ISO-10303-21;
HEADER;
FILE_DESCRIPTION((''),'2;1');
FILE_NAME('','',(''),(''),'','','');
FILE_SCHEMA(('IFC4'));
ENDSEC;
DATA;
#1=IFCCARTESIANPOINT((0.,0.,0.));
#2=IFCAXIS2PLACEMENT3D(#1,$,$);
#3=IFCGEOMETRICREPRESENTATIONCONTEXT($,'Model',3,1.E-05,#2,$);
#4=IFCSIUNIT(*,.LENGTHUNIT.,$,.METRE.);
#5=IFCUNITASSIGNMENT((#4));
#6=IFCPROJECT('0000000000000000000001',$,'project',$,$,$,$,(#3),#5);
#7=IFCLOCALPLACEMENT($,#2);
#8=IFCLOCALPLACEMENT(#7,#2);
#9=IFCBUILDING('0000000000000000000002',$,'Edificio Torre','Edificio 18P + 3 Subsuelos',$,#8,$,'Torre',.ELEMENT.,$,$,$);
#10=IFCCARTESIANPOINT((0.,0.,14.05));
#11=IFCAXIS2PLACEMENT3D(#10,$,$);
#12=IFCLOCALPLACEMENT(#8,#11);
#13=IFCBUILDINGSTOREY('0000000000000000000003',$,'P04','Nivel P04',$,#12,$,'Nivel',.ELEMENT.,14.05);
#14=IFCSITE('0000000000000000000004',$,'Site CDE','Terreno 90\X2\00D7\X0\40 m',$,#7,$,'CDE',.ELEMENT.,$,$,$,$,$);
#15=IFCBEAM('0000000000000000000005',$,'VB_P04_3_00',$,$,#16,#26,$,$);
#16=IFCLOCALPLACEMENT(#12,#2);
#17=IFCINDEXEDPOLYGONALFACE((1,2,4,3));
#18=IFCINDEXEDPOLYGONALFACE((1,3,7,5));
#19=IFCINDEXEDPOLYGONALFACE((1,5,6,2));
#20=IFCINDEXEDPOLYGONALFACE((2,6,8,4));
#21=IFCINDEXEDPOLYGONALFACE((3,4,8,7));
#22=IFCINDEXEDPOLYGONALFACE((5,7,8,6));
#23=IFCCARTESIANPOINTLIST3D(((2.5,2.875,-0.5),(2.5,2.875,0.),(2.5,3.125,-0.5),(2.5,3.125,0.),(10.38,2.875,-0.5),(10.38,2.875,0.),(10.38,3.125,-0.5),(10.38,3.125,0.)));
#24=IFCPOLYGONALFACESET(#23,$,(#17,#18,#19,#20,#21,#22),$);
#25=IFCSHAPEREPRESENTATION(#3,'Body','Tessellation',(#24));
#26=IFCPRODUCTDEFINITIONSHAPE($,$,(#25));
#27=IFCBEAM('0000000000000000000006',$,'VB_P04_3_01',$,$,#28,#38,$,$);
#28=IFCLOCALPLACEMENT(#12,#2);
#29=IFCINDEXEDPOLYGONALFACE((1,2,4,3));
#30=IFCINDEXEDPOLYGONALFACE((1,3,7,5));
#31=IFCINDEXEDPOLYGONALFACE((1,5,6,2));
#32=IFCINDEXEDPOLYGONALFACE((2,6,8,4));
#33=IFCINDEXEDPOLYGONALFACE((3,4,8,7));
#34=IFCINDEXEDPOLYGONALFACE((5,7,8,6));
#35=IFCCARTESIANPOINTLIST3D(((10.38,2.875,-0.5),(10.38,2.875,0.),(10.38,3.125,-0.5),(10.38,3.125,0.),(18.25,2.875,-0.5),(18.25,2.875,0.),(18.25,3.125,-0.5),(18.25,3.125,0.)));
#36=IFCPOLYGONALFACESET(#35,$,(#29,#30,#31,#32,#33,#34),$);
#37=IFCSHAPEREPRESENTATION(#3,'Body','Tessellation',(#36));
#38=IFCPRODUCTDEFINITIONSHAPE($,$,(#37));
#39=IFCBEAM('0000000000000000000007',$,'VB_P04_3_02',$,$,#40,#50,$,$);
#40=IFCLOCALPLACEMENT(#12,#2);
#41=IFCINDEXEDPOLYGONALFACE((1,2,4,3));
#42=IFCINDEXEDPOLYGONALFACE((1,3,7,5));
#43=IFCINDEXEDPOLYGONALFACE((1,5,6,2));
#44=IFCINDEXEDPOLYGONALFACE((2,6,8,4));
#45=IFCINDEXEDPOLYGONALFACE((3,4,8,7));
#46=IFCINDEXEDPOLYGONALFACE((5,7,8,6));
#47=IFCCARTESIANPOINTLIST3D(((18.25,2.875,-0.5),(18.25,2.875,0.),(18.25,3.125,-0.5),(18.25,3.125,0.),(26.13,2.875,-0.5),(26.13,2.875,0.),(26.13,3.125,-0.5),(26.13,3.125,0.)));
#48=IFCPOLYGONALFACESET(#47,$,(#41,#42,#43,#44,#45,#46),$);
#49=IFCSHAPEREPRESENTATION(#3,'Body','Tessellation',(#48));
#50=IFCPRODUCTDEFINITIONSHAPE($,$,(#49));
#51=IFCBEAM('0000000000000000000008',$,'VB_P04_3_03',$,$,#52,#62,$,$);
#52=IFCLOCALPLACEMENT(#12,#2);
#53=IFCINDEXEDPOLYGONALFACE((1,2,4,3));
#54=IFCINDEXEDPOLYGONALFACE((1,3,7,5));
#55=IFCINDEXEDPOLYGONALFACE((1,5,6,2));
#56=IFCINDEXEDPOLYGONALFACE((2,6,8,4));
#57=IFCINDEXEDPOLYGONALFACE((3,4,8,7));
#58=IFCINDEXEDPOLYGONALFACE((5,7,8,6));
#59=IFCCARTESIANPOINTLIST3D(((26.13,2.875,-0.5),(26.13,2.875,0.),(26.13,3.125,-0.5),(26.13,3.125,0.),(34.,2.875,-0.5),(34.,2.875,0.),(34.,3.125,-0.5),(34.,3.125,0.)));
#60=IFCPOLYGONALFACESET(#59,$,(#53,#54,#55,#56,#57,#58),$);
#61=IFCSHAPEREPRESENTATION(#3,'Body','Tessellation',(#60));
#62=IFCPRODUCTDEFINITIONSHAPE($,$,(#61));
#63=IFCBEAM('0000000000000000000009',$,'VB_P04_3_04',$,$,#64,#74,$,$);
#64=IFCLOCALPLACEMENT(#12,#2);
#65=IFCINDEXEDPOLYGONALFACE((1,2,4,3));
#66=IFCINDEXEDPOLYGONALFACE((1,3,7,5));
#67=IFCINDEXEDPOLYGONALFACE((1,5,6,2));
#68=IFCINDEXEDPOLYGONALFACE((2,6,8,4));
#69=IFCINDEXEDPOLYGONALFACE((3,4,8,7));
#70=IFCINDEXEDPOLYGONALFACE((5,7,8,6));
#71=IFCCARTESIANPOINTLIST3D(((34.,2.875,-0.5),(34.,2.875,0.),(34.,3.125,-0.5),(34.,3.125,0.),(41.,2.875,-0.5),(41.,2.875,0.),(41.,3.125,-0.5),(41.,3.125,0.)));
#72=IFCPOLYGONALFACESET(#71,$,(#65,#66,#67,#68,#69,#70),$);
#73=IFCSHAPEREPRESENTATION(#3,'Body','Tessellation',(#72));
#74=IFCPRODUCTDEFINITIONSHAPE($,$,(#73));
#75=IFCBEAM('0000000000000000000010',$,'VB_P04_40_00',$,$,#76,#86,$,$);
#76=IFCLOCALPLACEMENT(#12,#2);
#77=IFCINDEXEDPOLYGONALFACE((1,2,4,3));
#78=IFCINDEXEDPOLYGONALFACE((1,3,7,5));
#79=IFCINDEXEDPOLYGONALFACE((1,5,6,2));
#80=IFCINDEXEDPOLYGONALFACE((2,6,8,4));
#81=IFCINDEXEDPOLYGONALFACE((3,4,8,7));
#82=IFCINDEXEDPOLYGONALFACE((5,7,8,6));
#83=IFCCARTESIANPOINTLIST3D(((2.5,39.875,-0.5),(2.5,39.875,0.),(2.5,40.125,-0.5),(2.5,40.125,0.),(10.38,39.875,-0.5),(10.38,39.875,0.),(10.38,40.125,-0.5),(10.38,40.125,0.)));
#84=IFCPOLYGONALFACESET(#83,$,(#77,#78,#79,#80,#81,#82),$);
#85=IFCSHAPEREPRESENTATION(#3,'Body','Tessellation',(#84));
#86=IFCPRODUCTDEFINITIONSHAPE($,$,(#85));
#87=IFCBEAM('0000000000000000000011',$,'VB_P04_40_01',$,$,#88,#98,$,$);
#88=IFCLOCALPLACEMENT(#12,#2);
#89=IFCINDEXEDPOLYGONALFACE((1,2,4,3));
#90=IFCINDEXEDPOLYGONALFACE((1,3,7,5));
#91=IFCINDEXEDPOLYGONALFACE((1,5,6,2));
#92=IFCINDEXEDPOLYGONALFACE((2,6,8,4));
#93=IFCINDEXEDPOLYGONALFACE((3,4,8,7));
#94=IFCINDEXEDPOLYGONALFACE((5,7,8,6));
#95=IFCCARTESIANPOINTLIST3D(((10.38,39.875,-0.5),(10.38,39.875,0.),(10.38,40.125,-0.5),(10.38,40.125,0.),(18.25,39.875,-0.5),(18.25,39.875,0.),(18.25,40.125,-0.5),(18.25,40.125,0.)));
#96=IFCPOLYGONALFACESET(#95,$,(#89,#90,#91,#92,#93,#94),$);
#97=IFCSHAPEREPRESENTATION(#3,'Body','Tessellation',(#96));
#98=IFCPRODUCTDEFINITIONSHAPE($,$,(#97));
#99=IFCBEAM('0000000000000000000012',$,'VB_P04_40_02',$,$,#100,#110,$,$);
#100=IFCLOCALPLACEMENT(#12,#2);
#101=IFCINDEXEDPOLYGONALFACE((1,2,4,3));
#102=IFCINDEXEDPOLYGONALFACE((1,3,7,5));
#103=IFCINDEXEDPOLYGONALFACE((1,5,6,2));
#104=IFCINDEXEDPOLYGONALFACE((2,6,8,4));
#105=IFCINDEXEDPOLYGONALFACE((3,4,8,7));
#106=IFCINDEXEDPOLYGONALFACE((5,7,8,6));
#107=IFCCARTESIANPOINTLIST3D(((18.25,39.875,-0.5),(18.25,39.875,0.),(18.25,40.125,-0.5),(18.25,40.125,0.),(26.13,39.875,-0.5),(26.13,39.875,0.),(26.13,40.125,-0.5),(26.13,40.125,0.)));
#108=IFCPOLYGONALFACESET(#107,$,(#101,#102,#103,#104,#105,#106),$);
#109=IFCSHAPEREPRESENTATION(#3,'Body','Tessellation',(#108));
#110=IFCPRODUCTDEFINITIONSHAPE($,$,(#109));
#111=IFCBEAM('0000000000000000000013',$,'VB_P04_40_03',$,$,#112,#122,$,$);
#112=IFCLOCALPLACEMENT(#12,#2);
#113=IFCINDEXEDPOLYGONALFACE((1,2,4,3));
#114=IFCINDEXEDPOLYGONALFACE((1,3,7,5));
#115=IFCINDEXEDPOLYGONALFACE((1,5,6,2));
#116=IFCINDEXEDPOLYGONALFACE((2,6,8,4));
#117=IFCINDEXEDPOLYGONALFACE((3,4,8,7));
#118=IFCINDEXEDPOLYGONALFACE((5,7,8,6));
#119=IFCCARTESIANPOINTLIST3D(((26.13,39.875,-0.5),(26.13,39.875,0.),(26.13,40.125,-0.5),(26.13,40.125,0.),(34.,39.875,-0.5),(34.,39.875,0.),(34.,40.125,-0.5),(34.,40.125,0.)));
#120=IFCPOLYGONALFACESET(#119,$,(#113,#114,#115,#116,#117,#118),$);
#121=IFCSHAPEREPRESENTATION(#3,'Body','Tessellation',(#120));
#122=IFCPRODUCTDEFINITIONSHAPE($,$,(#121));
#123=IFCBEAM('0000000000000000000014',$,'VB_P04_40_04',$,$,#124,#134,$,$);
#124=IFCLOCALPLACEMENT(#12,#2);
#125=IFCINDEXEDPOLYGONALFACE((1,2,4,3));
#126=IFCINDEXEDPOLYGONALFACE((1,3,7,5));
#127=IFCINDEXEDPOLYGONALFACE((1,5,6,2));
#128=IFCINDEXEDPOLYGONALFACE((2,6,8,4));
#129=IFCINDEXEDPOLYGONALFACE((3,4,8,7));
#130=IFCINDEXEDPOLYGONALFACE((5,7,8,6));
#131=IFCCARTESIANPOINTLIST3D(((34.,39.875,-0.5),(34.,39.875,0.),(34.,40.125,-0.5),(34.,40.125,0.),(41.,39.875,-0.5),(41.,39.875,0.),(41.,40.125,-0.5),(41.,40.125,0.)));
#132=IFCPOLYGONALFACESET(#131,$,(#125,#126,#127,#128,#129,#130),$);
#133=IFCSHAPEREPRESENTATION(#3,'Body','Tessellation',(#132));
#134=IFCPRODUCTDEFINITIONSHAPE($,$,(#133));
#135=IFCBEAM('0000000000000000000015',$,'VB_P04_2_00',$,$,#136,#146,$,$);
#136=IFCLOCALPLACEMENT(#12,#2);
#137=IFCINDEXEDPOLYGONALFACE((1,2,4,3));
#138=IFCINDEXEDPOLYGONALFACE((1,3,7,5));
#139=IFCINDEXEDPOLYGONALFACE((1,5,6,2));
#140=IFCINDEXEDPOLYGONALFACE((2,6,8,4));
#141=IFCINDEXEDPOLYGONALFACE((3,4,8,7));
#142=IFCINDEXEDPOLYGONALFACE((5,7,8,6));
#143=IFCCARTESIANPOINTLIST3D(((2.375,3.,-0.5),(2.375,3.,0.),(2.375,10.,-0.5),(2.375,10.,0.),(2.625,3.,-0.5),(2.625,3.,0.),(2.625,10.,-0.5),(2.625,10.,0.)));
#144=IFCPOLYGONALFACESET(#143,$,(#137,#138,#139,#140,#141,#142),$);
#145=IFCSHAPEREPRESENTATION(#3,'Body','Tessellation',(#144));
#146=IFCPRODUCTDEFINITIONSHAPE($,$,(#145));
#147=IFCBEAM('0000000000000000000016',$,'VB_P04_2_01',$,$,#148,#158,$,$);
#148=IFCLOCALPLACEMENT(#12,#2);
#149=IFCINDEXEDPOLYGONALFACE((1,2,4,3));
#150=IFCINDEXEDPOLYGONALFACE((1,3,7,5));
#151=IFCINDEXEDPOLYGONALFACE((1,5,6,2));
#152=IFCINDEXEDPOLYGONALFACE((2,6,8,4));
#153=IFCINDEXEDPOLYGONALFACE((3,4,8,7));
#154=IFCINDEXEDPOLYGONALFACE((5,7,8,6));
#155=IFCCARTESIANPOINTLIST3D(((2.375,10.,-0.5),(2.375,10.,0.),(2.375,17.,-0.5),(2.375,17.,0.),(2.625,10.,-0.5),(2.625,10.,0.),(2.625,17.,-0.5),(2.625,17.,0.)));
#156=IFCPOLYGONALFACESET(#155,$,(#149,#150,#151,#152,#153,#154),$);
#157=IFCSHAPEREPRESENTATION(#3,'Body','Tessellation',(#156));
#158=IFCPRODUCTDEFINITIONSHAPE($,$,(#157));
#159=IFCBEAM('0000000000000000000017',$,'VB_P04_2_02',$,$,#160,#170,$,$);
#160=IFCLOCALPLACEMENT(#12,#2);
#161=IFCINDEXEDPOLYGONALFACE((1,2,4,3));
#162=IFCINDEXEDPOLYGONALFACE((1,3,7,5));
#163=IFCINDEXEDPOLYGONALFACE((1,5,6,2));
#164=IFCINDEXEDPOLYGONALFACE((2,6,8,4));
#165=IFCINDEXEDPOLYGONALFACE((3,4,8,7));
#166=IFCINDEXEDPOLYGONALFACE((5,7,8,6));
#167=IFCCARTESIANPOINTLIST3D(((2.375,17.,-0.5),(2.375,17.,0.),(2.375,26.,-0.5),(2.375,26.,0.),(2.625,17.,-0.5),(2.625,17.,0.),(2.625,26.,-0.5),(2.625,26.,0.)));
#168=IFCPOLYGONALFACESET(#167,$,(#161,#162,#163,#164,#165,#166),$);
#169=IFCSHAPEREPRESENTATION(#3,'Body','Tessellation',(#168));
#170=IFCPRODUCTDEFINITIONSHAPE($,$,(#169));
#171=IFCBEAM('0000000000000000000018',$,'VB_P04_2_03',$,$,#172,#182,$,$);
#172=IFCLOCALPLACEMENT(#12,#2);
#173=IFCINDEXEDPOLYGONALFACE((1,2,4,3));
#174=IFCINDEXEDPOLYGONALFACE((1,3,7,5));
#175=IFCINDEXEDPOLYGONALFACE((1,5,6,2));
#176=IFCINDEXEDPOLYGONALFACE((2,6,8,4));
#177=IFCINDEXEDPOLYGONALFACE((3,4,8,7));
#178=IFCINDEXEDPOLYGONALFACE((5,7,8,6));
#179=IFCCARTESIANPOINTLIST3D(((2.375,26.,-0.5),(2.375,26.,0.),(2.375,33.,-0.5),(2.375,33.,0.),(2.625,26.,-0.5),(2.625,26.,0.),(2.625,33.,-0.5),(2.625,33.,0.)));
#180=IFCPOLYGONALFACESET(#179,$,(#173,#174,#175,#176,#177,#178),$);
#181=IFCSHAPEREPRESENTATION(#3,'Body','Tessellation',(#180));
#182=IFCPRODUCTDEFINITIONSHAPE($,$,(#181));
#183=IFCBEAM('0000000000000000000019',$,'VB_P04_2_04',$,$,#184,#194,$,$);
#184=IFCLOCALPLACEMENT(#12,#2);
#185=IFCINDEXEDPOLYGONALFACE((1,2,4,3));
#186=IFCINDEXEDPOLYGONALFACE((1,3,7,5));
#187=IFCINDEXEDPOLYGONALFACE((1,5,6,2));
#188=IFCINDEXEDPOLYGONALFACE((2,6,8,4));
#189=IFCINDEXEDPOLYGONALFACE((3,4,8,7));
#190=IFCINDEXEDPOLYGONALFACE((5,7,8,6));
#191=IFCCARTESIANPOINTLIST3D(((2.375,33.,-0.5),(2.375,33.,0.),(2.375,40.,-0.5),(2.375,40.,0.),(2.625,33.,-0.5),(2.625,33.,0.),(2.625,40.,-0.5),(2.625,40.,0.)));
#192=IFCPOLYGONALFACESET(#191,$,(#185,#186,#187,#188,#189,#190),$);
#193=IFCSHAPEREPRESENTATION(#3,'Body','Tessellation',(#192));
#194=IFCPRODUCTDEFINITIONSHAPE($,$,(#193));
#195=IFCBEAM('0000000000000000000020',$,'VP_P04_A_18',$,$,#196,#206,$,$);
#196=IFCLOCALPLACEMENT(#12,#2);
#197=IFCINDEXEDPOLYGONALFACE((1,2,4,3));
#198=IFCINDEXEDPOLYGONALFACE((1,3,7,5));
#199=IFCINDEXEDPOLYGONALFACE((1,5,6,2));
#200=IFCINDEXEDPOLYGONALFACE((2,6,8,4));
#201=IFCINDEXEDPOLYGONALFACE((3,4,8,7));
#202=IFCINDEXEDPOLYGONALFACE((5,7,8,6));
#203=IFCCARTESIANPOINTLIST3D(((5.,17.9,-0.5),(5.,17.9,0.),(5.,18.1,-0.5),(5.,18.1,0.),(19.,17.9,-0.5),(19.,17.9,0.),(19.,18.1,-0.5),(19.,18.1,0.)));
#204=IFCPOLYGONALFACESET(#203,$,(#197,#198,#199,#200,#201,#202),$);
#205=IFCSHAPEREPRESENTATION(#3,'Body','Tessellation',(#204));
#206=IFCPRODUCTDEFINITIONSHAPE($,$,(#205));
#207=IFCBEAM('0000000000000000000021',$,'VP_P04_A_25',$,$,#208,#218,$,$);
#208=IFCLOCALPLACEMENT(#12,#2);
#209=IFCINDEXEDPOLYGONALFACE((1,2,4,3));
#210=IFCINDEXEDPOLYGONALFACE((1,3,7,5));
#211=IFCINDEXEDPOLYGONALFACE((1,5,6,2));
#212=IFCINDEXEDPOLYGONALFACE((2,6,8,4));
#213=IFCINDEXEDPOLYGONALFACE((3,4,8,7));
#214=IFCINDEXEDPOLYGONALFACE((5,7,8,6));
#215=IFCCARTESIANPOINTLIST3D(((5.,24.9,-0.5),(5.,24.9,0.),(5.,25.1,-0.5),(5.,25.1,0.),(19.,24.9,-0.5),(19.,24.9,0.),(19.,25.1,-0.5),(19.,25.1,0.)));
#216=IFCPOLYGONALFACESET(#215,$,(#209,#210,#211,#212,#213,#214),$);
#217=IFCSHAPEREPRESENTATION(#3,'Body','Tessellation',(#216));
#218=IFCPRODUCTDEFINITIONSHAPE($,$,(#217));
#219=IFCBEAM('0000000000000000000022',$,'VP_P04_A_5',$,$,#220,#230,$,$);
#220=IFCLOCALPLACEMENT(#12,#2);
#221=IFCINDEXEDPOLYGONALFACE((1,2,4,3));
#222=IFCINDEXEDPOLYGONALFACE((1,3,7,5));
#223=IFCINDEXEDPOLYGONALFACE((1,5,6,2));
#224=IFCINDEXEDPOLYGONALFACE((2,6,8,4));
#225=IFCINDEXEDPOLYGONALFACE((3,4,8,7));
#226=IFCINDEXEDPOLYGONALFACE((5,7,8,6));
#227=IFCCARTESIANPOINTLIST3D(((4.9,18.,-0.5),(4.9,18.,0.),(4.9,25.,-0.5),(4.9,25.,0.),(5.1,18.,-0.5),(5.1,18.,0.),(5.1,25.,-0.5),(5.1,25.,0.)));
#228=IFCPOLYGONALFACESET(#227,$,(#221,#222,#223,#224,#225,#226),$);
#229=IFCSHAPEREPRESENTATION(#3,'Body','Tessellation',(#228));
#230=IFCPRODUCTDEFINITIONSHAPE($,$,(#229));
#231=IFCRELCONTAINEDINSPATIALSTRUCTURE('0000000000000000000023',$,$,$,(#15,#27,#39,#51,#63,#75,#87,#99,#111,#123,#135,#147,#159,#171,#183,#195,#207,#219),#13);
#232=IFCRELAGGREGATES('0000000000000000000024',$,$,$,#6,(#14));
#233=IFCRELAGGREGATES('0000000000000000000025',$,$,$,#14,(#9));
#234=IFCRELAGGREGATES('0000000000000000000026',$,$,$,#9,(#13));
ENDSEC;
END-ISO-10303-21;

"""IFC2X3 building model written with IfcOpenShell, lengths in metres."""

from ifc_helpers import new_model, si_unit, frame, origin, origin_2d, place, context, project, spatial, rectangle, extrude, element, save


model = new_model("IFC2X3")

# Units and contexts
model_context = context("Model", 3, precision=1e-05, world=origin())
ifc_project = project(units=[si_unit("LENGTHUNIT", "METRE")], contexts=[model_context])

# Site, building, storey
site_placement = place(None, origin())
site = spatial("IfcSite", under=ifc_project, at=site_placement, Name="Site CDE", Description="Terreno 90×40 m", LongName="CDE", CompositionType="ELEMENT")
building_placement = place(site_placement, origin())
building = spatial("IfcBuilding", under=site, at=building_placement, Name="Edificio Torre", Description="Edificio 18P + 3 Subsuelos", LongName="Torre", CompositionType="ELEMENT")
storey_placement = place(building_placement, frame((0.0, 0.0, 14.05)))
storey = spatial("IfcBuildingStorey", under=building, at=storey_placement, Name="P04", Description="Nivel P04", LongName="Nivel", CompositionType="ELEMENT", Elevation=14.05)

# Beams
beam_1_placement = place(storey_placement, frame((6.44, 3.0, -0.5)))
element("IfcBeam", 1, at=beam_1_placement, inside=storey, Name="VB_P04_3_00", context=model_context, shape_type="SweptSolid", body=[
    extrude(rectangle(XDim=7.88, YDim=0.25, at=origin_2d()), origin(), (0.0, 0.0, 1.0), 0.5),
])
beam_2_placement = place(storey_placement, frame((14.315, 3.0, -0.5)))
element("IfcBeam", 2, at=beam_2_placement, inside=storey, Name="VB_P04_3_01", context=model_context, shape_type="SweptSolid", body=[
    extrude(rectangle(XDim=7.87, YDim=0.25, at=origin_2d()), origin(), (0.0, 0.0, 1.0), 0.5),
])
beam_3_placement = place(storey_placement, frame((22.19, 3.0, -0.5)))
element("IfcBeam", 3, at=beam_3_placement, inside=storey, Name="VB_P04_3_02", context=model_context, shape_type="SweptSolid", body=[
    extrude(rectangle(XDim=7.88, YDim=0.25, at=origin_2d()), origin(), (0.0, 0.0, 1.0), 0.5),
])
beam_4_placement = place(storey_placement, frame((30.065, 3.0, -0.5)))
element("IfcBeam", 4, at=beam_4_placement, inside=storey, Name="VB_P04_3_03", context=model_context, shape_type="SweptSolid", body=[
    extrude(rectangle(XDim=7.87, YDim=0.25, at=origin_2d()), origin(), (0.0, 0.0, 1.0), 0.5),
])
beam_5_placement = place(storey_placement, frame((37.5, 3.0, -0.5)))
element("IfcBeam", 5, at=beam_5_placement, inside=storey, Name="VB_P04_3_04", context=model_context, shape_type="SweptSolid", body=[
    extrude(rectangle(XDim=7.0, YDim=0.25, at=origin_2d()), origin(), (0.0, 0.0, 1.0), 0.5),
])
beam_6_placement = place(storey_placement, frame((6.44, 40.0, -0.5)))
element("IfcBeam", 6, at=beam_6_placement, inside=storey, Name="VB_P04_40_00", context=model_context, shape_type="SweptSolid", body=[
    extrude(rectangle(XDim=7.88, YDim=0.25, at=origin_2d()), origin(), (0.0, 0.0, 1.0), 0.5),
])
beam_7_placement = place(storey_placement, frame((14.315, 40.0, -0.5)))
element("IfcBeam", 7, at=beam_7_placement, inside=storey, Name="VB_P04_40_01", context=model_context, shape_type="SweptSolid", body=[
    extrude(rectangle(XDim=7.87, YDim=0.25, at=origin_2d()), origin(), (0.0, 0.0, 1.0), 0.5),
])
beam_8_placement = place(storey_placement, frame((22.19, 40.0, -0.5)))
element("IfcBeam", 8, at=beam_8_placement, inside=storey, Name="VB_P04_40_02", context=model_context, shape_type="SweptSolid", body=[
    extrude(rectangle(XDim=7.88, YDim=0.25, at=origin_2d()), origin(), (0.0, 0.0, 1.0), 0.5),
])
beam_9_placement = place(storey_placement, frame((30.065, 40.0, -0.5)))
element("IfcBeam", 9, at=beam_9_placement, inside=storey, Name="VB_P04_40_03", context=model_context, shape_type="SweptSolid", body=[
    extrude(rectangle(XDim=7.87, YDim=0.25, at=origin_2d()), origin(), (0.0, 0.0, 1.0), 0.5),
])
beam_10_placement = place(storey_placement, frame((37.5, 40.0, -0.5)))
element("IfcBeam", 10, at=beam_10_placement, inside=storey, Name="VB_P04_40_04", context=model_context, shape_type="SweptSolid", body=[
    extrude(rectangle(XDim=7.0, YDim=0.25, at=origin_2d()), origin(), (0.0, 0.0, 1.0), 0.5),
])
for number, where, name in (
    (11, (2.5, 6.5, -0.5), "VB_P04_2_00"),
    (12, (2.5, 13.5, -0.5), "VB_P04_2_01"),
):
    element("IfcBeam", number, at=place(storey_placement, frame(where)), inside=storey, Name=name, context=model_context, shape_type="SweptSolid", body=[
        extrude(rectangle(XDim=0.25, YDim=7.0, at=origin_2d()), origin(), (0.0, 0.0, 1.0), 0.5),
    ])
beam_11_placement = place(storey_placement, frame((2.5, 21.5, -0.5)))
element("IfcBeam", 13, at=beam_11_placement, inside=storey, Name="VB_P04_2_02", context=model_context, shape_type="SweptSolid", body=[
    extrude(rectangle(XDim=0.25, YDim=9.0, at=origin_2d()), origin(), (0.0, 0.0, 1.0), 0.5),
])
for number, where, name in (
    (14, (2.5, 29.5, -0.5), "VB_P04_2_03"),
    (15, (2.5, 36.5, -0.5), "VB_P04_2_04"),
):
    element("IfcBeam", number, at=place(storey_placement, frame(where)), inside=storey, Name=name, context=model_context, shape_type="SweptSolid", body=[
        extrude(rectangle(XDim=0.25, YDim=7.0, at=origin_2d()), origin(), (0.0, 0.0, 1.0), 0.5),
    ])
for number, where, name in (
    (16, (12.0, 18.0, -0.5), "VP_P04_A_18"),
    (17, (12.0, 25.0, -0.5), "VP_P04_A_25"),
):
    element("IfcBeam", number, at=place(storey_placement, frame(where)), inside=storey, Name=name, context=model_context, shape_type="SweptSolid", body=[
        extrude(rectangle(XDim=14.0, YDim=0.2, at=origin_2d()), origin(), (0.0, 0.0, 1.0), 0.5),
    ])
beam_12_placement = place(storey_placement, frame((5.0, 21.5, -0.5)))
element("IfcBeam", 18, at=beam_12_placement, inside=storey, Name="VP_P04_A_5", context=model_context, shape_type="SweptSolid", body=[
    extrude(rectangle(XDim=0.2, YDim=7.0, at=origin_2d()), origin(), (0.0, 0.0, 1.0), 0.5),
])

save(model, "model.ifc")
